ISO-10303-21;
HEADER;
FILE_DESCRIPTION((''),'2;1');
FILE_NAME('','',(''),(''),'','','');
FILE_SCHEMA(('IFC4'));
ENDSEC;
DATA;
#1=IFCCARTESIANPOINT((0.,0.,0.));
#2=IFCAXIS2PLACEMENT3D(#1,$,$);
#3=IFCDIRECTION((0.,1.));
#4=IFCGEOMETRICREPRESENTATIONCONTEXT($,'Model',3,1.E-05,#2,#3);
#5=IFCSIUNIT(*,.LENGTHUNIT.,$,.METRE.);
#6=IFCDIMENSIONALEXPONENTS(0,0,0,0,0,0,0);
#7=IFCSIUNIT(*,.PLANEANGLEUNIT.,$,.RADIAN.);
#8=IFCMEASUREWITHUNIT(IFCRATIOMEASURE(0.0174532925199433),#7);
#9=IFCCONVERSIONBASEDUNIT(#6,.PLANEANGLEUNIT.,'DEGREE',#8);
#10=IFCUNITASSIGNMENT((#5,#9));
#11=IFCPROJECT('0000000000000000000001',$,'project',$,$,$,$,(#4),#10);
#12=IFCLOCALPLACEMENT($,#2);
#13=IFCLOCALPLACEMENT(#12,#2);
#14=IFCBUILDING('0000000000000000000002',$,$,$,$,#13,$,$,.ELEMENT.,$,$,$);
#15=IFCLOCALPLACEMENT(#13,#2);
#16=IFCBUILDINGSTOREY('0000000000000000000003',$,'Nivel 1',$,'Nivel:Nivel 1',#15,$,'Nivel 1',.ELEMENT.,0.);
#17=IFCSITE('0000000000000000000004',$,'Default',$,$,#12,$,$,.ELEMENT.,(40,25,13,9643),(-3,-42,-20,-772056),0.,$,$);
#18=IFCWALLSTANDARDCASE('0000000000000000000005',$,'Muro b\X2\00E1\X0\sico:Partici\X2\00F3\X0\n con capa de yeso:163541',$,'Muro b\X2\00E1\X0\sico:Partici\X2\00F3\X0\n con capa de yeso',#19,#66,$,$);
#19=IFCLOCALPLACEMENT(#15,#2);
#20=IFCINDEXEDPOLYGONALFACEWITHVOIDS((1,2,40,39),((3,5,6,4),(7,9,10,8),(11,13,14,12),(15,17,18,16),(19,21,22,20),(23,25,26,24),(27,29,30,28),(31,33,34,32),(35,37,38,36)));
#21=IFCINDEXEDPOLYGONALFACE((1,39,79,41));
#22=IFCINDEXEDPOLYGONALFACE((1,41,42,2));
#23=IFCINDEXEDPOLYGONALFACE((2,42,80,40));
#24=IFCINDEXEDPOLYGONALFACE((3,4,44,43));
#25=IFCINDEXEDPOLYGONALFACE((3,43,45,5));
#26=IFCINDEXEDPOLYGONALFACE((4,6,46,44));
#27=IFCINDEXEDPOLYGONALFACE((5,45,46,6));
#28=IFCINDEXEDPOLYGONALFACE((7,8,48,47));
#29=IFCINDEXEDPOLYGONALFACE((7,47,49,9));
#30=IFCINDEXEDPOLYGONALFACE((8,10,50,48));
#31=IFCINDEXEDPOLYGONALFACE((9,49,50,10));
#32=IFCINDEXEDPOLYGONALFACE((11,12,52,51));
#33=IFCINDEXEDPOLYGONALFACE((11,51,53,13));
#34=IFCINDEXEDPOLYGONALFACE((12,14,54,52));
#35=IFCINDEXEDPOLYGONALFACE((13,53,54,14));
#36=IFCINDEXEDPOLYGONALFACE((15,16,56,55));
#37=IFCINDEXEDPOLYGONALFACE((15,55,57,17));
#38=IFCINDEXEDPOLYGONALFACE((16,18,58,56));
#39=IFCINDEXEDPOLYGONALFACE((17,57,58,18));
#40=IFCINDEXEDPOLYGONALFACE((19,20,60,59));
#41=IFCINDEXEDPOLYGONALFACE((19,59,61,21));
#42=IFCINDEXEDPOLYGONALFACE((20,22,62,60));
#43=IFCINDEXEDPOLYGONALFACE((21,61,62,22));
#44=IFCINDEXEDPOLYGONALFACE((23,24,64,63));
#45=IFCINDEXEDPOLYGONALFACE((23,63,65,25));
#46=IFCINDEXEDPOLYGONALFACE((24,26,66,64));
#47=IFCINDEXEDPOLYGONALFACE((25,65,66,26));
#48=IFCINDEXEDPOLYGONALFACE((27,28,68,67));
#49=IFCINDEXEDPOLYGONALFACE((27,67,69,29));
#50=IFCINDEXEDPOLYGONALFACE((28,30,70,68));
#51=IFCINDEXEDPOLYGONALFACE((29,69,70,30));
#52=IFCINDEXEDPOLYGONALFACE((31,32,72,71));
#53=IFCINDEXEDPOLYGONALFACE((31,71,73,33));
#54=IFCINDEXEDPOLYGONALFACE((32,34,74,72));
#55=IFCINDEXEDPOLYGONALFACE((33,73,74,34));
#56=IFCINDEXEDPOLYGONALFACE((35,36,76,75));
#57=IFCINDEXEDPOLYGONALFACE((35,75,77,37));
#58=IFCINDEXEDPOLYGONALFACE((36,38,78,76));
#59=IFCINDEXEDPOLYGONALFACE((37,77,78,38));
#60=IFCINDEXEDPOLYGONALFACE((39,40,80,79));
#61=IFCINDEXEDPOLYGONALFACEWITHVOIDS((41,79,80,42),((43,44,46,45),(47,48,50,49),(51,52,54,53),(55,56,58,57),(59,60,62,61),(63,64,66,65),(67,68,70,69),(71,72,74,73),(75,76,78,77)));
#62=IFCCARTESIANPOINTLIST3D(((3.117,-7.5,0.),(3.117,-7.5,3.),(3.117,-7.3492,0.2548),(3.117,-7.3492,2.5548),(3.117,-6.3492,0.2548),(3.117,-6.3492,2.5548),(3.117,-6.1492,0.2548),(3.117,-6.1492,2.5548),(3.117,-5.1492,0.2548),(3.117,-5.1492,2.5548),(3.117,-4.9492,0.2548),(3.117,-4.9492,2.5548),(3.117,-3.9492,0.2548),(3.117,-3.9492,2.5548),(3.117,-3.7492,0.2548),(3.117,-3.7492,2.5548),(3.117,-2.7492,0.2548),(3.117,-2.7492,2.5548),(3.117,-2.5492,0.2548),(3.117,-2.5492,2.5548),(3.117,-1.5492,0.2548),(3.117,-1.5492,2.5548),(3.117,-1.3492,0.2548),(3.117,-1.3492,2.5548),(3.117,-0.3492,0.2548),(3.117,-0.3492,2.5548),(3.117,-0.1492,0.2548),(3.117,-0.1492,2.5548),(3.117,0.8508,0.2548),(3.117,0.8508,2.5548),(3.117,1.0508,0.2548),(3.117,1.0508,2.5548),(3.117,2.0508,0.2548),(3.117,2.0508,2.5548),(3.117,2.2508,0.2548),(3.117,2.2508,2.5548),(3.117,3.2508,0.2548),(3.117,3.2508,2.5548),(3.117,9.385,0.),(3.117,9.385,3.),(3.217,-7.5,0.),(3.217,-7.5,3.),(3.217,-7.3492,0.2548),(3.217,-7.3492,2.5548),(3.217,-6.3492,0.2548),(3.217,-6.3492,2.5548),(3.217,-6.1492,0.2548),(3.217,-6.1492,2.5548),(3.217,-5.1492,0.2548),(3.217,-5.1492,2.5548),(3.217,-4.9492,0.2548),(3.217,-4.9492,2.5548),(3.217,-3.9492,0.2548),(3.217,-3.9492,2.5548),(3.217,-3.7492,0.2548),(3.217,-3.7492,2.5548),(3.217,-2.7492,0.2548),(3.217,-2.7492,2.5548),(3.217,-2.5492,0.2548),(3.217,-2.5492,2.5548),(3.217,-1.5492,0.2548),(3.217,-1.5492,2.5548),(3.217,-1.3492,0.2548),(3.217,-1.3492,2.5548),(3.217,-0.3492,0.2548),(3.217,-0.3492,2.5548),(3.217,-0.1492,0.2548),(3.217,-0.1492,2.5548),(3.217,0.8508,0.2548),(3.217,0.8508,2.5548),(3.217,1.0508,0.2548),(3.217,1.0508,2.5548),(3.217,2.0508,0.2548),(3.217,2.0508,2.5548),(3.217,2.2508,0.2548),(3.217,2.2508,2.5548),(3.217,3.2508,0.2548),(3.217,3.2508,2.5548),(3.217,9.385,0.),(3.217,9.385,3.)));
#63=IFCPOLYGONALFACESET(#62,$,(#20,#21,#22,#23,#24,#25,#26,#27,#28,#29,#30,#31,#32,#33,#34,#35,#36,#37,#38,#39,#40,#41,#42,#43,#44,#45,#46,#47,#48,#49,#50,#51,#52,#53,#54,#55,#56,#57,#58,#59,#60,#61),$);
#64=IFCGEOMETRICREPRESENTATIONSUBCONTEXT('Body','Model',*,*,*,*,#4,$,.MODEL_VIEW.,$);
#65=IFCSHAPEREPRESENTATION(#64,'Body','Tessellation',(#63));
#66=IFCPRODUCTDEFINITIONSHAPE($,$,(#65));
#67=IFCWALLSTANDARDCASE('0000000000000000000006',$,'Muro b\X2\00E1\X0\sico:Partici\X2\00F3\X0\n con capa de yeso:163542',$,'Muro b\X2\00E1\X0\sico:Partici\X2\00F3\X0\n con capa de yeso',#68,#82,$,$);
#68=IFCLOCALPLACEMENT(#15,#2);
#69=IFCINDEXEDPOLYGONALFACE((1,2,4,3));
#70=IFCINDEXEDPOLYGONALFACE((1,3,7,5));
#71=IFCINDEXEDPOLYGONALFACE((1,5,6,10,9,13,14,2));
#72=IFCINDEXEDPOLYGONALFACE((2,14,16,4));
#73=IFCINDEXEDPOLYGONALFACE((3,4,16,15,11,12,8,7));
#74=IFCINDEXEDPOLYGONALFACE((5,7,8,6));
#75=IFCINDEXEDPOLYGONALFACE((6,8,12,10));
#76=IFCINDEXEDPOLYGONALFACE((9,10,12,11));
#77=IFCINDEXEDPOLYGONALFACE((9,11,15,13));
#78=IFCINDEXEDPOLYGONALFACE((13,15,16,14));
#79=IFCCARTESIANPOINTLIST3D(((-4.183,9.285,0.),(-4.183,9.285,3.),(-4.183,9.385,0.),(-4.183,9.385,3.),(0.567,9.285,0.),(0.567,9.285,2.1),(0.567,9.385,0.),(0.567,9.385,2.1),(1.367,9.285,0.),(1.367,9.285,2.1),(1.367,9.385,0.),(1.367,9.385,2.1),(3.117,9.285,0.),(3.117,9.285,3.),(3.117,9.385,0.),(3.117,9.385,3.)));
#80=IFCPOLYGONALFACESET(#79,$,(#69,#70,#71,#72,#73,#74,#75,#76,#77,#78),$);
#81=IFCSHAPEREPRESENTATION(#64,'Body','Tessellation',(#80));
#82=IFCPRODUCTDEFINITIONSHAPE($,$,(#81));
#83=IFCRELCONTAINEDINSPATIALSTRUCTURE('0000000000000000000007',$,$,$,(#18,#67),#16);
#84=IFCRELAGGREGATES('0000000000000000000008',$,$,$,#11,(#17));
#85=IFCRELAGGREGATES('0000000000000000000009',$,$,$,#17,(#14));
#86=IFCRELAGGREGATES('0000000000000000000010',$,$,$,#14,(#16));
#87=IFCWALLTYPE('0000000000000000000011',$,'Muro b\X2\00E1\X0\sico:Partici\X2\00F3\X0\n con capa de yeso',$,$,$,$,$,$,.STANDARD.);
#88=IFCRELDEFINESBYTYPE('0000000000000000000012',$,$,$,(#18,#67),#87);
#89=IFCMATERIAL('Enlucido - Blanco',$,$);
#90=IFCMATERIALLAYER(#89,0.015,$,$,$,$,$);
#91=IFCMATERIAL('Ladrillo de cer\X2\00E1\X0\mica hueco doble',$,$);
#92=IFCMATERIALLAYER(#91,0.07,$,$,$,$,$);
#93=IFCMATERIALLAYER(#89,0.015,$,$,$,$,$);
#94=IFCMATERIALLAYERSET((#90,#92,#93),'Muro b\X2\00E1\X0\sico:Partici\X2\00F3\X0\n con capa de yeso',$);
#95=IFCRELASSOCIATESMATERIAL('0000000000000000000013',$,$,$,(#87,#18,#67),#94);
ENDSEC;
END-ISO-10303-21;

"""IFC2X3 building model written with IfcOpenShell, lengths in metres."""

from ifc_helpers import new_model, entity, si_unit, converted_unit, direction, frame, frame_2d, origin, place, context, subcontext, project, spatial, rectangle, extrude, material, layer, layer_set, layer_usage, type_object, element, save


model = new_model("IFC2X3")

# Units and contexts
model_context = context("Model", 3, precision=1e-05, world=origin(), true_north=direction((0.0, 1.0)))
body_context = subcontext(model_context, "Body", "Model", "MODEL_VIEW")
ifc_project = project(units=[si_unit("LENGTHUNIT", "METRE"), converted_unit("PLANEANGLEUNIT", "DEGREE", entity("IfcRatioMeasure", 0.0174532925199433), si_unit("PLANEANGLEUNIT", "RADIAN"), dimensions=[0, 0, 0, 0, 0, 0, 0])], contexts=[model_context])

# Site, building, storey
site_placement = place(None, origin())
site = spatial("IfcSite", under=ifc_project, at=site_placement, Name="Default", CompositionType="ELEMENT", RefLatitude=(40, 25, 13, 9643), RefLongitude=(-3, -42, -20, -772056), RefElevation=0.0)
building_placement = place(site_placement, origin())
building = spatial("IfcBuilding", under=site, at=building_placement, CompositionType="ELEMENT")
storey_placement = place(building_placement, origin())
storey = spatial("IfcBuildingStorey", under=building, at=storey_placement, Name="Nivel 1", ObjectType="Nivel:Nivel 1", LongName="Nivel 1", CompositionType="ELEMENT", Elevation=0.0)

# Wall, openings
ifc_material_1 = material(Name="Enlucido - Blanco")
ifc_layer_1 = layer(ifc_material_1, 0.015)
ifc_material_2 = material(Name="Ladrillo de cerámica hueco doble")
ifc_layer_2 = layer(ifc_material_2, 0.07)
ifc_layer_3 = layer(ifc_material_1, 0.015)
ifc_layer_set_1 = layer_set([ifc_layer_1, ifc_layer_2, ifc_layer_3], Name="Muro básico:Partición con capa de yeso")
ifc_layer_usage_1 = layer_usage(ifc_layer_set_1, "AXIS2", "NEGATIVE", 0.05)
wall_type = type_object("IfcWallType", Name="Muro básico:Partición con capa de yeso", PredefinedType="STANDARD", material=ifc_layer_set_1)
wall_1_placement = place(storey_placement, frame((3.167, 9.385, 0.0), z_axis=(0.0, 0.0, 1.0), x_axis=(0.0, -1.0, 0.0)))
wall_1 = element("IfcWallStandardCase", 1, at=wall_1_placement, inside=storey, type_object=wall_type, material=ifc_layer_usage_1, Name="Muro básico:Partición con capa de yeso:163541", ObjectType="Muro básico:Partición con capa de yeso", context=body_context, shape_type="SweptSolid", body=[
    extrude(rectangle(XDim=16.885, YDim=0.1, at=frame_2d((8.4425, 0.0), x_axis=(-1.0, 0.0))), origin(), (0.0, 0.0, 1.0), 3.0),
])
opening_1_placement = place(wall_1_placement, frame((15.7342, -0.05, 0.2548)))
element("IfcOpeningElement", 2, at=opening_1_placement, cuts=wall_1, ObjectType="Opening", context=body_context, shape_type="SweptSolid", body=[
    extrude(rectangle(XDim=2.3, YDim=1.0, at=frame_2d((1.15, 0.5), x_axis=(1.0, 0.0))), frame((0.0, 0.0, 0.0), z_axis=(0.0, 1.0, 0.0), x_axis=(0.0, 0.0, 1.0)), (0.0, 0.0, 1.0), 0.1),
])
opening_2_placement = place(wall_1_placement, frame((14.5342, -0.05, 0.2548)))
element("IfcOpeningElement", 3, at=opening_2_placement, cuts=wall_1, ObjectType="Opening", context=body_context, shape_type="SweptSolid", body=[
    extrude(rectangle(XDim=2.3, YDim=1.0, at=frame_2d((1.15, 0.5), x_axis=(1.0, 0.0))), frame((0.0, 0.0, 0.0), z_axis=(0.0, 1.0, 0.0), x_axis=(0.0, 0.0, 1.0)), (0.0, 0.0, 1.0), 0.1),
])
opening_3_placement = place(wall_1_placement, frame((13.3342, -0.05, 0.2548)))
element("IfcOpeningElement", 4, at=opening_3_placement, cuts=wall_1, ObjectType="Opening", context=body_context, shape_type="SweptSolid", body=[
    extrude(rectangle(XDim=2.3, YDim=1.0, at=frame_2d((1.15, 0.5), x_axis=(1.0, 0.0))), frame((0.0, 0.0, 0.0), z_axis=(0.0, 1.0, 0.0), x_axis=(0.0, 0.0, 1.0)), (0.0, 0.0, 1.0), 0.1),
])
opening_4_placement = place(wall_1_placement, frame((12.1342, -0.05, 0.2548)))
element("IfcOpeningElement", 5, at=opening_4_placement, cuts=wall_1, ObjectType="Opening", context=body_context, shape_type="SweptSolid", body=[
    extrude(rectangle(XDim=2.3, YDim=1.0, at=frame_2d((1.15, 0.5), x_axis=(1.0, 0.0))), frame((0.0, 0.0, 0.0), z_axis=(0.0, 1.0, 0.0), x_axis=(0.0, 0.0, 1.0)), (0.0, 0.0, 1.0), 0.1),
])
opening_5_placement = place(wall_1_placement, frame((10.9342, -0.05, 0.2548)))
element("IfcOpeningElement", 6, at=opening_5_placement, cuts=wall_1, ObjectType="Opening", context=body_context, shape_type="SweptSolid", body=[
    extrude(rectangle(XDim=2.3, YDim=1.0, at=frame_2d((1.15, 0.5), x_axis=(1.0, 0.0))), frame((0.0, 0.0, 0.0), z_axis=(0.0, 1.0, 0.0), x_axis=(0.0, 0.0, 1.0)), (0.0, 0.0, 1.0), 0.1),
])
opening_6_placement = place(wall_1_placement, frame((9.7342, -0.05, 0.2548)))
element("IfcOpeningElement", 7, at=opening_6_placement, cuts=wall_1, ObjectType="Opening", context=body_context, shape_type="SweptSolid", body=[
    extrude(rectangle(XDim=2.3, YDim=1.0, at=frame_2d((1.15, 0.5), x_axis=(1.0, 0.0))), frame((0.0, 0.0, 0.0), z_axis=(0.0, 1.0, 0.0), x_axis=(0.0, 0.0, 1.0)), (0.0, 0.0, 1.0), 0.1),
])
opening_7_placement = place(wall_1_placement, frame((8.5342, -0.05, 0.2548)))
element("IfcOpeningElement", 8, at=opening_7_placement, cuts=wall_1, ObjectType="Opening", context=body_context, shape_type="SweptSolid", body=[
    extrude(rectangle(XDim=2.3, YDim=1.0, at=frame_2d((1.15, 0.5), x_axis=(1.0, 0.0))), frame((0.0, 0.0, 0.0), z_axis=(0.0, 1.0, 0.0), x_axis=(0.0, 0.0, 1.0)), (0.0, 0.0, 1.0), 0.1),
])
opening_8_placement = place(wall_1_placement, frame((7.3342, -0.05, 0.2548)))
element("IfcOpeningElement", 9, at=opening_8_placement, cuts=wall_1, ObjectType="Opening", context=body_context, shape_type="SweptSolid", body=[
    extrude(rectangle(XDim=2.3, YDim=1.0, at=frame_2d((1.15, 0.5), x_axis=(1.0, 0.0))), frame((0.0, 0.0, 0.0), z_axis=(0.0, 1.0, 0.0), x_axis=(0.0, 0.0, 1.0)), (0.0, 0.0, 1.0), 0.1),
])
opening_9_placement = place(wall_1_placement, frame((6.1342, -0.05, 0.2548)))
element("IfcOpeningElement", 10, at=opening_9_placement, cuts=wall_1, ObjectType="Opening", context=body_context, shape_type="SweptSolid", body=[
    extrude(rectangle(XDim=2.3, YDim=1.0, at=frame_2d((1.15, 0.5), x_axis=(1.0, 0.0))), frame((0.0, 0.0, 0.0), z_axis=(0.0, 1.0, 0.0), x_axis=(0.0, 0.0, 1.0)), (0.0, 0.0, 1.0), 0.1),
])

# Wall, opening
ifc_layer_usage_2 = layer_usage(ifc_layer_set_1, "AXIS2", "NEGATIVE", 0.05)
wall_2_placement = place(storey_placement, frame((-4.183, 9.335, 0.0)))
wall_2 = element("IfcWallStandardCase", 11, at=wall_2_placement, inside=storey, type_object=wall_type, material=ifc_layer_usage_2, Name="Muro básico:Partición con capa de yeso:163542", ObjectType="Muro básico:Partición con capa de yeso", context=body_context, shape_type="SweptSolid", body=[
    extrude(rectangle(XDim=7.3, YDim=0.1, at=frame_2d((3.65, 0.0), x_axis=(-1.0, 0.0))), origin(), (0.0, 0.0, 1.0), 3.0),
])
opening_10_placement = place(wall_2_placement, frame((5.55, 0.05, 0.0)))
element("IfcOpeningElement", 12, at=opening_10_placement, cuts=wall_2, ObjectType="Opening", context=body_context, shape_type="SweptSolid", body=[
    extrude(rectangle(XDim=2.1, YDim=0.8, at=frame_2d((1.05, 0.4), x_axis=(1.0, 0.0))), frame((0.0, 0.0, 0.0), z_axis=(0.0, -1.0, 0.0), x_axis=(0.0, 0.0, 1.0)), (0.0, 0.0, 1.0), 0.1),
])

save(model, "model.ifc")
